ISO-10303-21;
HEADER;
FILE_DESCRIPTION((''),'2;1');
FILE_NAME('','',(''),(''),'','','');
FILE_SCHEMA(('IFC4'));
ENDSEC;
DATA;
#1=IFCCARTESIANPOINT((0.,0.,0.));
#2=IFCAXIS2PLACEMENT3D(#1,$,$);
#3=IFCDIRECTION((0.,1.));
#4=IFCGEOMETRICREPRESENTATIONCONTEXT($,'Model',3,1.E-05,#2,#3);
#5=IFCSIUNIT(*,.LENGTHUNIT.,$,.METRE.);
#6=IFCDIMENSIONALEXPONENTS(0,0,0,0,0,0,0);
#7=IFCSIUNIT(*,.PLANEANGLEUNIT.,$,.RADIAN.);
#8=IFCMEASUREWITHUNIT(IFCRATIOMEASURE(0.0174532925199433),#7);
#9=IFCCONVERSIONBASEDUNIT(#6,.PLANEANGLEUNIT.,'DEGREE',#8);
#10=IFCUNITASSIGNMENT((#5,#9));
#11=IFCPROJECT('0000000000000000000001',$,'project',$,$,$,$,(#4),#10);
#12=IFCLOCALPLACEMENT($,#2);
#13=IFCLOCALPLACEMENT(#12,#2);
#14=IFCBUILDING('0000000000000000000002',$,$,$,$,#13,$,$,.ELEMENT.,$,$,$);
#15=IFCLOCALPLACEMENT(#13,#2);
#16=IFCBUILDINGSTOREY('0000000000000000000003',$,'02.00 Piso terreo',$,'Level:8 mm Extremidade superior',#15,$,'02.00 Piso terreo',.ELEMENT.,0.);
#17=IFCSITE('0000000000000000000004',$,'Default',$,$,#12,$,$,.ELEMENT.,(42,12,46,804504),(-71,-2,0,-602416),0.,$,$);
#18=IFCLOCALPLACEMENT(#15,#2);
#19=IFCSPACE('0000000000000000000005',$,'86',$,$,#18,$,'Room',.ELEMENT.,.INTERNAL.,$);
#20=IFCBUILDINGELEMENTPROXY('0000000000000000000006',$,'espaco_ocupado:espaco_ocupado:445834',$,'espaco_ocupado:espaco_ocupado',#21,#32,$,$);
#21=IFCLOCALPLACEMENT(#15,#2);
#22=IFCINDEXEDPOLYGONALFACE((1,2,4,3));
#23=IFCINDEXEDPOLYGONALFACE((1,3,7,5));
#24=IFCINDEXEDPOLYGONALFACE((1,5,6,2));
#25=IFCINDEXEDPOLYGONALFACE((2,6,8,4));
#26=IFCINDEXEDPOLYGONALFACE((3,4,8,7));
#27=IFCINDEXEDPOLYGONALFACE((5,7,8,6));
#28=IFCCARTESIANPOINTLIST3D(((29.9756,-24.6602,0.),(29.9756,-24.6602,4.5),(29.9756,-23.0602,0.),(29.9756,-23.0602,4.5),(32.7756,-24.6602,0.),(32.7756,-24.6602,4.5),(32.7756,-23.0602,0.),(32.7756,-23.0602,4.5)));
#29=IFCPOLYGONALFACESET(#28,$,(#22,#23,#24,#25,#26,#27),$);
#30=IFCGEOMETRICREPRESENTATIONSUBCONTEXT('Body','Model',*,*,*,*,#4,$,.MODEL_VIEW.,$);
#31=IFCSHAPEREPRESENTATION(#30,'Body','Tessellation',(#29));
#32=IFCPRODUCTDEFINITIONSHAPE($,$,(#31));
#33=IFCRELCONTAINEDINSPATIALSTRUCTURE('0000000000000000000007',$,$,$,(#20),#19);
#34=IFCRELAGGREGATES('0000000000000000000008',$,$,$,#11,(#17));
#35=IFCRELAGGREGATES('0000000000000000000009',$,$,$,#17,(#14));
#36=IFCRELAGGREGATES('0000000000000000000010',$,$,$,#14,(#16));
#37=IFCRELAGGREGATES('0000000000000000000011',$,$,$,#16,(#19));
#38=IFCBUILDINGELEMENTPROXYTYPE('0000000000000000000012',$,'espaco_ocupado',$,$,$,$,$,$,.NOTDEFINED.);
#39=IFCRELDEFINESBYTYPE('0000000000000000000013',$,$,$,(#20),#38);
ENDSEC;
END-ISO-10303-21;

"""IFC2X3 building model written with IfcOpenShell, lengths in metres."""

from ifc_helpers import new_model, entity, si_unit, converted_unit, direction, frame, origin, origin_2d_with_axis, place, context, subcontext, project, spatial, rectangle, extrude, source, transform, mapped, type_object, type_shapes, element, save


model = new_model("IFC2X3")

# Units and contexts
model_context = context("Model", 3, precision=1e-05, world=origin(), true_north=direction((0.0, 1.0)))
body_context = subcontext(model_context, "Body", "Model", "MODEL_VIEW")
ifc_project = project(units=[si_unit("LENGTHUNIT", "METRE"), converted_unit("PLANEANGLEUNIT", "DEGREE", entity("IfcRatioMeasure", 0.0174532925199433), si_unit("PLANEANGLEUNIT", "RADIAN"), dimensions=[0, 0, 0, 0, 0, 0, 0])], contexts=[model_context])

# Site, building, storey
site_placement = place(None, origin())
site = spatial("IfcSite", under=ifc_project, at=site_placement, Name="Default", CompositionType="ELEMENT", RefLatitude=(42, 12, 46, 804504), RefLongitude=(-71, -2, 0, -602416), RefElevation=0.0)
building_placement = place(site_placement, origin())
building = spatial("IfcBuilding", under=site, at=building_placement, CompositionType="ELEMENT")
storey_placement = place(building_placement, origin())
storey = spatial("IfcBuildingStorey", under=building, at=storey_placement, Name="02.00 Piso terreo", ObjectType="Level:8 mm Extremidade superior", LongName="02.00 Piso terreo", CompositionType="ELEMENT", Elevation=0.0)

# Shared definitions
space_1_placement = place(storey_placement, origin())
space_1 = spatial("IfcSpace", under=storey, at=space_1_placement, Name="86", LongName="Room", CompositionType="ELEMENT", InteriorOrExteriorSpace="INTERNAL")

# Building element proxy
building_element_proxy_type_1 = type_object("IfcBuildingElementProxyType", Name="espaco_ocupado", PredefinedType="NOTDEFINED")
shared_shape_1 = source(origin(), body_context, "Body", "SweptSolid", [
    extrude(rectangle(XDim=2.8, YDim=1.6, at=origin_2d_with_axis()), frame((0.0, 0.0, 0.0), z_axis=(0.0, 0.0, 1.0), x_axis=(-1.0, 0.0, 0.0)), (0.0, 0.0, 1.0), 4.5),
])
type_shapes(building_element_proxy_type_1, [shared_shape_1])
proxy_1_placement = place(space_1_placement, frame((31.3756, -23.8602, 0.0)))
element("IfcBuildingElementProxy", 1, at=proxy_1_placement, inside=space_1, type_object=building_element_proxy_type_1, Name="espaco_ocupado:espaco_ocupado:445834", ObjectType="espaco_ocupado:espaco_ocupado", context=body_context, shape_type="MappedRepresentation", body=[
    mapped(shared_shape_1, transform((0.0, 0.0, 0.0), scale=1.0)),
])

save(model, "model.ifc")
